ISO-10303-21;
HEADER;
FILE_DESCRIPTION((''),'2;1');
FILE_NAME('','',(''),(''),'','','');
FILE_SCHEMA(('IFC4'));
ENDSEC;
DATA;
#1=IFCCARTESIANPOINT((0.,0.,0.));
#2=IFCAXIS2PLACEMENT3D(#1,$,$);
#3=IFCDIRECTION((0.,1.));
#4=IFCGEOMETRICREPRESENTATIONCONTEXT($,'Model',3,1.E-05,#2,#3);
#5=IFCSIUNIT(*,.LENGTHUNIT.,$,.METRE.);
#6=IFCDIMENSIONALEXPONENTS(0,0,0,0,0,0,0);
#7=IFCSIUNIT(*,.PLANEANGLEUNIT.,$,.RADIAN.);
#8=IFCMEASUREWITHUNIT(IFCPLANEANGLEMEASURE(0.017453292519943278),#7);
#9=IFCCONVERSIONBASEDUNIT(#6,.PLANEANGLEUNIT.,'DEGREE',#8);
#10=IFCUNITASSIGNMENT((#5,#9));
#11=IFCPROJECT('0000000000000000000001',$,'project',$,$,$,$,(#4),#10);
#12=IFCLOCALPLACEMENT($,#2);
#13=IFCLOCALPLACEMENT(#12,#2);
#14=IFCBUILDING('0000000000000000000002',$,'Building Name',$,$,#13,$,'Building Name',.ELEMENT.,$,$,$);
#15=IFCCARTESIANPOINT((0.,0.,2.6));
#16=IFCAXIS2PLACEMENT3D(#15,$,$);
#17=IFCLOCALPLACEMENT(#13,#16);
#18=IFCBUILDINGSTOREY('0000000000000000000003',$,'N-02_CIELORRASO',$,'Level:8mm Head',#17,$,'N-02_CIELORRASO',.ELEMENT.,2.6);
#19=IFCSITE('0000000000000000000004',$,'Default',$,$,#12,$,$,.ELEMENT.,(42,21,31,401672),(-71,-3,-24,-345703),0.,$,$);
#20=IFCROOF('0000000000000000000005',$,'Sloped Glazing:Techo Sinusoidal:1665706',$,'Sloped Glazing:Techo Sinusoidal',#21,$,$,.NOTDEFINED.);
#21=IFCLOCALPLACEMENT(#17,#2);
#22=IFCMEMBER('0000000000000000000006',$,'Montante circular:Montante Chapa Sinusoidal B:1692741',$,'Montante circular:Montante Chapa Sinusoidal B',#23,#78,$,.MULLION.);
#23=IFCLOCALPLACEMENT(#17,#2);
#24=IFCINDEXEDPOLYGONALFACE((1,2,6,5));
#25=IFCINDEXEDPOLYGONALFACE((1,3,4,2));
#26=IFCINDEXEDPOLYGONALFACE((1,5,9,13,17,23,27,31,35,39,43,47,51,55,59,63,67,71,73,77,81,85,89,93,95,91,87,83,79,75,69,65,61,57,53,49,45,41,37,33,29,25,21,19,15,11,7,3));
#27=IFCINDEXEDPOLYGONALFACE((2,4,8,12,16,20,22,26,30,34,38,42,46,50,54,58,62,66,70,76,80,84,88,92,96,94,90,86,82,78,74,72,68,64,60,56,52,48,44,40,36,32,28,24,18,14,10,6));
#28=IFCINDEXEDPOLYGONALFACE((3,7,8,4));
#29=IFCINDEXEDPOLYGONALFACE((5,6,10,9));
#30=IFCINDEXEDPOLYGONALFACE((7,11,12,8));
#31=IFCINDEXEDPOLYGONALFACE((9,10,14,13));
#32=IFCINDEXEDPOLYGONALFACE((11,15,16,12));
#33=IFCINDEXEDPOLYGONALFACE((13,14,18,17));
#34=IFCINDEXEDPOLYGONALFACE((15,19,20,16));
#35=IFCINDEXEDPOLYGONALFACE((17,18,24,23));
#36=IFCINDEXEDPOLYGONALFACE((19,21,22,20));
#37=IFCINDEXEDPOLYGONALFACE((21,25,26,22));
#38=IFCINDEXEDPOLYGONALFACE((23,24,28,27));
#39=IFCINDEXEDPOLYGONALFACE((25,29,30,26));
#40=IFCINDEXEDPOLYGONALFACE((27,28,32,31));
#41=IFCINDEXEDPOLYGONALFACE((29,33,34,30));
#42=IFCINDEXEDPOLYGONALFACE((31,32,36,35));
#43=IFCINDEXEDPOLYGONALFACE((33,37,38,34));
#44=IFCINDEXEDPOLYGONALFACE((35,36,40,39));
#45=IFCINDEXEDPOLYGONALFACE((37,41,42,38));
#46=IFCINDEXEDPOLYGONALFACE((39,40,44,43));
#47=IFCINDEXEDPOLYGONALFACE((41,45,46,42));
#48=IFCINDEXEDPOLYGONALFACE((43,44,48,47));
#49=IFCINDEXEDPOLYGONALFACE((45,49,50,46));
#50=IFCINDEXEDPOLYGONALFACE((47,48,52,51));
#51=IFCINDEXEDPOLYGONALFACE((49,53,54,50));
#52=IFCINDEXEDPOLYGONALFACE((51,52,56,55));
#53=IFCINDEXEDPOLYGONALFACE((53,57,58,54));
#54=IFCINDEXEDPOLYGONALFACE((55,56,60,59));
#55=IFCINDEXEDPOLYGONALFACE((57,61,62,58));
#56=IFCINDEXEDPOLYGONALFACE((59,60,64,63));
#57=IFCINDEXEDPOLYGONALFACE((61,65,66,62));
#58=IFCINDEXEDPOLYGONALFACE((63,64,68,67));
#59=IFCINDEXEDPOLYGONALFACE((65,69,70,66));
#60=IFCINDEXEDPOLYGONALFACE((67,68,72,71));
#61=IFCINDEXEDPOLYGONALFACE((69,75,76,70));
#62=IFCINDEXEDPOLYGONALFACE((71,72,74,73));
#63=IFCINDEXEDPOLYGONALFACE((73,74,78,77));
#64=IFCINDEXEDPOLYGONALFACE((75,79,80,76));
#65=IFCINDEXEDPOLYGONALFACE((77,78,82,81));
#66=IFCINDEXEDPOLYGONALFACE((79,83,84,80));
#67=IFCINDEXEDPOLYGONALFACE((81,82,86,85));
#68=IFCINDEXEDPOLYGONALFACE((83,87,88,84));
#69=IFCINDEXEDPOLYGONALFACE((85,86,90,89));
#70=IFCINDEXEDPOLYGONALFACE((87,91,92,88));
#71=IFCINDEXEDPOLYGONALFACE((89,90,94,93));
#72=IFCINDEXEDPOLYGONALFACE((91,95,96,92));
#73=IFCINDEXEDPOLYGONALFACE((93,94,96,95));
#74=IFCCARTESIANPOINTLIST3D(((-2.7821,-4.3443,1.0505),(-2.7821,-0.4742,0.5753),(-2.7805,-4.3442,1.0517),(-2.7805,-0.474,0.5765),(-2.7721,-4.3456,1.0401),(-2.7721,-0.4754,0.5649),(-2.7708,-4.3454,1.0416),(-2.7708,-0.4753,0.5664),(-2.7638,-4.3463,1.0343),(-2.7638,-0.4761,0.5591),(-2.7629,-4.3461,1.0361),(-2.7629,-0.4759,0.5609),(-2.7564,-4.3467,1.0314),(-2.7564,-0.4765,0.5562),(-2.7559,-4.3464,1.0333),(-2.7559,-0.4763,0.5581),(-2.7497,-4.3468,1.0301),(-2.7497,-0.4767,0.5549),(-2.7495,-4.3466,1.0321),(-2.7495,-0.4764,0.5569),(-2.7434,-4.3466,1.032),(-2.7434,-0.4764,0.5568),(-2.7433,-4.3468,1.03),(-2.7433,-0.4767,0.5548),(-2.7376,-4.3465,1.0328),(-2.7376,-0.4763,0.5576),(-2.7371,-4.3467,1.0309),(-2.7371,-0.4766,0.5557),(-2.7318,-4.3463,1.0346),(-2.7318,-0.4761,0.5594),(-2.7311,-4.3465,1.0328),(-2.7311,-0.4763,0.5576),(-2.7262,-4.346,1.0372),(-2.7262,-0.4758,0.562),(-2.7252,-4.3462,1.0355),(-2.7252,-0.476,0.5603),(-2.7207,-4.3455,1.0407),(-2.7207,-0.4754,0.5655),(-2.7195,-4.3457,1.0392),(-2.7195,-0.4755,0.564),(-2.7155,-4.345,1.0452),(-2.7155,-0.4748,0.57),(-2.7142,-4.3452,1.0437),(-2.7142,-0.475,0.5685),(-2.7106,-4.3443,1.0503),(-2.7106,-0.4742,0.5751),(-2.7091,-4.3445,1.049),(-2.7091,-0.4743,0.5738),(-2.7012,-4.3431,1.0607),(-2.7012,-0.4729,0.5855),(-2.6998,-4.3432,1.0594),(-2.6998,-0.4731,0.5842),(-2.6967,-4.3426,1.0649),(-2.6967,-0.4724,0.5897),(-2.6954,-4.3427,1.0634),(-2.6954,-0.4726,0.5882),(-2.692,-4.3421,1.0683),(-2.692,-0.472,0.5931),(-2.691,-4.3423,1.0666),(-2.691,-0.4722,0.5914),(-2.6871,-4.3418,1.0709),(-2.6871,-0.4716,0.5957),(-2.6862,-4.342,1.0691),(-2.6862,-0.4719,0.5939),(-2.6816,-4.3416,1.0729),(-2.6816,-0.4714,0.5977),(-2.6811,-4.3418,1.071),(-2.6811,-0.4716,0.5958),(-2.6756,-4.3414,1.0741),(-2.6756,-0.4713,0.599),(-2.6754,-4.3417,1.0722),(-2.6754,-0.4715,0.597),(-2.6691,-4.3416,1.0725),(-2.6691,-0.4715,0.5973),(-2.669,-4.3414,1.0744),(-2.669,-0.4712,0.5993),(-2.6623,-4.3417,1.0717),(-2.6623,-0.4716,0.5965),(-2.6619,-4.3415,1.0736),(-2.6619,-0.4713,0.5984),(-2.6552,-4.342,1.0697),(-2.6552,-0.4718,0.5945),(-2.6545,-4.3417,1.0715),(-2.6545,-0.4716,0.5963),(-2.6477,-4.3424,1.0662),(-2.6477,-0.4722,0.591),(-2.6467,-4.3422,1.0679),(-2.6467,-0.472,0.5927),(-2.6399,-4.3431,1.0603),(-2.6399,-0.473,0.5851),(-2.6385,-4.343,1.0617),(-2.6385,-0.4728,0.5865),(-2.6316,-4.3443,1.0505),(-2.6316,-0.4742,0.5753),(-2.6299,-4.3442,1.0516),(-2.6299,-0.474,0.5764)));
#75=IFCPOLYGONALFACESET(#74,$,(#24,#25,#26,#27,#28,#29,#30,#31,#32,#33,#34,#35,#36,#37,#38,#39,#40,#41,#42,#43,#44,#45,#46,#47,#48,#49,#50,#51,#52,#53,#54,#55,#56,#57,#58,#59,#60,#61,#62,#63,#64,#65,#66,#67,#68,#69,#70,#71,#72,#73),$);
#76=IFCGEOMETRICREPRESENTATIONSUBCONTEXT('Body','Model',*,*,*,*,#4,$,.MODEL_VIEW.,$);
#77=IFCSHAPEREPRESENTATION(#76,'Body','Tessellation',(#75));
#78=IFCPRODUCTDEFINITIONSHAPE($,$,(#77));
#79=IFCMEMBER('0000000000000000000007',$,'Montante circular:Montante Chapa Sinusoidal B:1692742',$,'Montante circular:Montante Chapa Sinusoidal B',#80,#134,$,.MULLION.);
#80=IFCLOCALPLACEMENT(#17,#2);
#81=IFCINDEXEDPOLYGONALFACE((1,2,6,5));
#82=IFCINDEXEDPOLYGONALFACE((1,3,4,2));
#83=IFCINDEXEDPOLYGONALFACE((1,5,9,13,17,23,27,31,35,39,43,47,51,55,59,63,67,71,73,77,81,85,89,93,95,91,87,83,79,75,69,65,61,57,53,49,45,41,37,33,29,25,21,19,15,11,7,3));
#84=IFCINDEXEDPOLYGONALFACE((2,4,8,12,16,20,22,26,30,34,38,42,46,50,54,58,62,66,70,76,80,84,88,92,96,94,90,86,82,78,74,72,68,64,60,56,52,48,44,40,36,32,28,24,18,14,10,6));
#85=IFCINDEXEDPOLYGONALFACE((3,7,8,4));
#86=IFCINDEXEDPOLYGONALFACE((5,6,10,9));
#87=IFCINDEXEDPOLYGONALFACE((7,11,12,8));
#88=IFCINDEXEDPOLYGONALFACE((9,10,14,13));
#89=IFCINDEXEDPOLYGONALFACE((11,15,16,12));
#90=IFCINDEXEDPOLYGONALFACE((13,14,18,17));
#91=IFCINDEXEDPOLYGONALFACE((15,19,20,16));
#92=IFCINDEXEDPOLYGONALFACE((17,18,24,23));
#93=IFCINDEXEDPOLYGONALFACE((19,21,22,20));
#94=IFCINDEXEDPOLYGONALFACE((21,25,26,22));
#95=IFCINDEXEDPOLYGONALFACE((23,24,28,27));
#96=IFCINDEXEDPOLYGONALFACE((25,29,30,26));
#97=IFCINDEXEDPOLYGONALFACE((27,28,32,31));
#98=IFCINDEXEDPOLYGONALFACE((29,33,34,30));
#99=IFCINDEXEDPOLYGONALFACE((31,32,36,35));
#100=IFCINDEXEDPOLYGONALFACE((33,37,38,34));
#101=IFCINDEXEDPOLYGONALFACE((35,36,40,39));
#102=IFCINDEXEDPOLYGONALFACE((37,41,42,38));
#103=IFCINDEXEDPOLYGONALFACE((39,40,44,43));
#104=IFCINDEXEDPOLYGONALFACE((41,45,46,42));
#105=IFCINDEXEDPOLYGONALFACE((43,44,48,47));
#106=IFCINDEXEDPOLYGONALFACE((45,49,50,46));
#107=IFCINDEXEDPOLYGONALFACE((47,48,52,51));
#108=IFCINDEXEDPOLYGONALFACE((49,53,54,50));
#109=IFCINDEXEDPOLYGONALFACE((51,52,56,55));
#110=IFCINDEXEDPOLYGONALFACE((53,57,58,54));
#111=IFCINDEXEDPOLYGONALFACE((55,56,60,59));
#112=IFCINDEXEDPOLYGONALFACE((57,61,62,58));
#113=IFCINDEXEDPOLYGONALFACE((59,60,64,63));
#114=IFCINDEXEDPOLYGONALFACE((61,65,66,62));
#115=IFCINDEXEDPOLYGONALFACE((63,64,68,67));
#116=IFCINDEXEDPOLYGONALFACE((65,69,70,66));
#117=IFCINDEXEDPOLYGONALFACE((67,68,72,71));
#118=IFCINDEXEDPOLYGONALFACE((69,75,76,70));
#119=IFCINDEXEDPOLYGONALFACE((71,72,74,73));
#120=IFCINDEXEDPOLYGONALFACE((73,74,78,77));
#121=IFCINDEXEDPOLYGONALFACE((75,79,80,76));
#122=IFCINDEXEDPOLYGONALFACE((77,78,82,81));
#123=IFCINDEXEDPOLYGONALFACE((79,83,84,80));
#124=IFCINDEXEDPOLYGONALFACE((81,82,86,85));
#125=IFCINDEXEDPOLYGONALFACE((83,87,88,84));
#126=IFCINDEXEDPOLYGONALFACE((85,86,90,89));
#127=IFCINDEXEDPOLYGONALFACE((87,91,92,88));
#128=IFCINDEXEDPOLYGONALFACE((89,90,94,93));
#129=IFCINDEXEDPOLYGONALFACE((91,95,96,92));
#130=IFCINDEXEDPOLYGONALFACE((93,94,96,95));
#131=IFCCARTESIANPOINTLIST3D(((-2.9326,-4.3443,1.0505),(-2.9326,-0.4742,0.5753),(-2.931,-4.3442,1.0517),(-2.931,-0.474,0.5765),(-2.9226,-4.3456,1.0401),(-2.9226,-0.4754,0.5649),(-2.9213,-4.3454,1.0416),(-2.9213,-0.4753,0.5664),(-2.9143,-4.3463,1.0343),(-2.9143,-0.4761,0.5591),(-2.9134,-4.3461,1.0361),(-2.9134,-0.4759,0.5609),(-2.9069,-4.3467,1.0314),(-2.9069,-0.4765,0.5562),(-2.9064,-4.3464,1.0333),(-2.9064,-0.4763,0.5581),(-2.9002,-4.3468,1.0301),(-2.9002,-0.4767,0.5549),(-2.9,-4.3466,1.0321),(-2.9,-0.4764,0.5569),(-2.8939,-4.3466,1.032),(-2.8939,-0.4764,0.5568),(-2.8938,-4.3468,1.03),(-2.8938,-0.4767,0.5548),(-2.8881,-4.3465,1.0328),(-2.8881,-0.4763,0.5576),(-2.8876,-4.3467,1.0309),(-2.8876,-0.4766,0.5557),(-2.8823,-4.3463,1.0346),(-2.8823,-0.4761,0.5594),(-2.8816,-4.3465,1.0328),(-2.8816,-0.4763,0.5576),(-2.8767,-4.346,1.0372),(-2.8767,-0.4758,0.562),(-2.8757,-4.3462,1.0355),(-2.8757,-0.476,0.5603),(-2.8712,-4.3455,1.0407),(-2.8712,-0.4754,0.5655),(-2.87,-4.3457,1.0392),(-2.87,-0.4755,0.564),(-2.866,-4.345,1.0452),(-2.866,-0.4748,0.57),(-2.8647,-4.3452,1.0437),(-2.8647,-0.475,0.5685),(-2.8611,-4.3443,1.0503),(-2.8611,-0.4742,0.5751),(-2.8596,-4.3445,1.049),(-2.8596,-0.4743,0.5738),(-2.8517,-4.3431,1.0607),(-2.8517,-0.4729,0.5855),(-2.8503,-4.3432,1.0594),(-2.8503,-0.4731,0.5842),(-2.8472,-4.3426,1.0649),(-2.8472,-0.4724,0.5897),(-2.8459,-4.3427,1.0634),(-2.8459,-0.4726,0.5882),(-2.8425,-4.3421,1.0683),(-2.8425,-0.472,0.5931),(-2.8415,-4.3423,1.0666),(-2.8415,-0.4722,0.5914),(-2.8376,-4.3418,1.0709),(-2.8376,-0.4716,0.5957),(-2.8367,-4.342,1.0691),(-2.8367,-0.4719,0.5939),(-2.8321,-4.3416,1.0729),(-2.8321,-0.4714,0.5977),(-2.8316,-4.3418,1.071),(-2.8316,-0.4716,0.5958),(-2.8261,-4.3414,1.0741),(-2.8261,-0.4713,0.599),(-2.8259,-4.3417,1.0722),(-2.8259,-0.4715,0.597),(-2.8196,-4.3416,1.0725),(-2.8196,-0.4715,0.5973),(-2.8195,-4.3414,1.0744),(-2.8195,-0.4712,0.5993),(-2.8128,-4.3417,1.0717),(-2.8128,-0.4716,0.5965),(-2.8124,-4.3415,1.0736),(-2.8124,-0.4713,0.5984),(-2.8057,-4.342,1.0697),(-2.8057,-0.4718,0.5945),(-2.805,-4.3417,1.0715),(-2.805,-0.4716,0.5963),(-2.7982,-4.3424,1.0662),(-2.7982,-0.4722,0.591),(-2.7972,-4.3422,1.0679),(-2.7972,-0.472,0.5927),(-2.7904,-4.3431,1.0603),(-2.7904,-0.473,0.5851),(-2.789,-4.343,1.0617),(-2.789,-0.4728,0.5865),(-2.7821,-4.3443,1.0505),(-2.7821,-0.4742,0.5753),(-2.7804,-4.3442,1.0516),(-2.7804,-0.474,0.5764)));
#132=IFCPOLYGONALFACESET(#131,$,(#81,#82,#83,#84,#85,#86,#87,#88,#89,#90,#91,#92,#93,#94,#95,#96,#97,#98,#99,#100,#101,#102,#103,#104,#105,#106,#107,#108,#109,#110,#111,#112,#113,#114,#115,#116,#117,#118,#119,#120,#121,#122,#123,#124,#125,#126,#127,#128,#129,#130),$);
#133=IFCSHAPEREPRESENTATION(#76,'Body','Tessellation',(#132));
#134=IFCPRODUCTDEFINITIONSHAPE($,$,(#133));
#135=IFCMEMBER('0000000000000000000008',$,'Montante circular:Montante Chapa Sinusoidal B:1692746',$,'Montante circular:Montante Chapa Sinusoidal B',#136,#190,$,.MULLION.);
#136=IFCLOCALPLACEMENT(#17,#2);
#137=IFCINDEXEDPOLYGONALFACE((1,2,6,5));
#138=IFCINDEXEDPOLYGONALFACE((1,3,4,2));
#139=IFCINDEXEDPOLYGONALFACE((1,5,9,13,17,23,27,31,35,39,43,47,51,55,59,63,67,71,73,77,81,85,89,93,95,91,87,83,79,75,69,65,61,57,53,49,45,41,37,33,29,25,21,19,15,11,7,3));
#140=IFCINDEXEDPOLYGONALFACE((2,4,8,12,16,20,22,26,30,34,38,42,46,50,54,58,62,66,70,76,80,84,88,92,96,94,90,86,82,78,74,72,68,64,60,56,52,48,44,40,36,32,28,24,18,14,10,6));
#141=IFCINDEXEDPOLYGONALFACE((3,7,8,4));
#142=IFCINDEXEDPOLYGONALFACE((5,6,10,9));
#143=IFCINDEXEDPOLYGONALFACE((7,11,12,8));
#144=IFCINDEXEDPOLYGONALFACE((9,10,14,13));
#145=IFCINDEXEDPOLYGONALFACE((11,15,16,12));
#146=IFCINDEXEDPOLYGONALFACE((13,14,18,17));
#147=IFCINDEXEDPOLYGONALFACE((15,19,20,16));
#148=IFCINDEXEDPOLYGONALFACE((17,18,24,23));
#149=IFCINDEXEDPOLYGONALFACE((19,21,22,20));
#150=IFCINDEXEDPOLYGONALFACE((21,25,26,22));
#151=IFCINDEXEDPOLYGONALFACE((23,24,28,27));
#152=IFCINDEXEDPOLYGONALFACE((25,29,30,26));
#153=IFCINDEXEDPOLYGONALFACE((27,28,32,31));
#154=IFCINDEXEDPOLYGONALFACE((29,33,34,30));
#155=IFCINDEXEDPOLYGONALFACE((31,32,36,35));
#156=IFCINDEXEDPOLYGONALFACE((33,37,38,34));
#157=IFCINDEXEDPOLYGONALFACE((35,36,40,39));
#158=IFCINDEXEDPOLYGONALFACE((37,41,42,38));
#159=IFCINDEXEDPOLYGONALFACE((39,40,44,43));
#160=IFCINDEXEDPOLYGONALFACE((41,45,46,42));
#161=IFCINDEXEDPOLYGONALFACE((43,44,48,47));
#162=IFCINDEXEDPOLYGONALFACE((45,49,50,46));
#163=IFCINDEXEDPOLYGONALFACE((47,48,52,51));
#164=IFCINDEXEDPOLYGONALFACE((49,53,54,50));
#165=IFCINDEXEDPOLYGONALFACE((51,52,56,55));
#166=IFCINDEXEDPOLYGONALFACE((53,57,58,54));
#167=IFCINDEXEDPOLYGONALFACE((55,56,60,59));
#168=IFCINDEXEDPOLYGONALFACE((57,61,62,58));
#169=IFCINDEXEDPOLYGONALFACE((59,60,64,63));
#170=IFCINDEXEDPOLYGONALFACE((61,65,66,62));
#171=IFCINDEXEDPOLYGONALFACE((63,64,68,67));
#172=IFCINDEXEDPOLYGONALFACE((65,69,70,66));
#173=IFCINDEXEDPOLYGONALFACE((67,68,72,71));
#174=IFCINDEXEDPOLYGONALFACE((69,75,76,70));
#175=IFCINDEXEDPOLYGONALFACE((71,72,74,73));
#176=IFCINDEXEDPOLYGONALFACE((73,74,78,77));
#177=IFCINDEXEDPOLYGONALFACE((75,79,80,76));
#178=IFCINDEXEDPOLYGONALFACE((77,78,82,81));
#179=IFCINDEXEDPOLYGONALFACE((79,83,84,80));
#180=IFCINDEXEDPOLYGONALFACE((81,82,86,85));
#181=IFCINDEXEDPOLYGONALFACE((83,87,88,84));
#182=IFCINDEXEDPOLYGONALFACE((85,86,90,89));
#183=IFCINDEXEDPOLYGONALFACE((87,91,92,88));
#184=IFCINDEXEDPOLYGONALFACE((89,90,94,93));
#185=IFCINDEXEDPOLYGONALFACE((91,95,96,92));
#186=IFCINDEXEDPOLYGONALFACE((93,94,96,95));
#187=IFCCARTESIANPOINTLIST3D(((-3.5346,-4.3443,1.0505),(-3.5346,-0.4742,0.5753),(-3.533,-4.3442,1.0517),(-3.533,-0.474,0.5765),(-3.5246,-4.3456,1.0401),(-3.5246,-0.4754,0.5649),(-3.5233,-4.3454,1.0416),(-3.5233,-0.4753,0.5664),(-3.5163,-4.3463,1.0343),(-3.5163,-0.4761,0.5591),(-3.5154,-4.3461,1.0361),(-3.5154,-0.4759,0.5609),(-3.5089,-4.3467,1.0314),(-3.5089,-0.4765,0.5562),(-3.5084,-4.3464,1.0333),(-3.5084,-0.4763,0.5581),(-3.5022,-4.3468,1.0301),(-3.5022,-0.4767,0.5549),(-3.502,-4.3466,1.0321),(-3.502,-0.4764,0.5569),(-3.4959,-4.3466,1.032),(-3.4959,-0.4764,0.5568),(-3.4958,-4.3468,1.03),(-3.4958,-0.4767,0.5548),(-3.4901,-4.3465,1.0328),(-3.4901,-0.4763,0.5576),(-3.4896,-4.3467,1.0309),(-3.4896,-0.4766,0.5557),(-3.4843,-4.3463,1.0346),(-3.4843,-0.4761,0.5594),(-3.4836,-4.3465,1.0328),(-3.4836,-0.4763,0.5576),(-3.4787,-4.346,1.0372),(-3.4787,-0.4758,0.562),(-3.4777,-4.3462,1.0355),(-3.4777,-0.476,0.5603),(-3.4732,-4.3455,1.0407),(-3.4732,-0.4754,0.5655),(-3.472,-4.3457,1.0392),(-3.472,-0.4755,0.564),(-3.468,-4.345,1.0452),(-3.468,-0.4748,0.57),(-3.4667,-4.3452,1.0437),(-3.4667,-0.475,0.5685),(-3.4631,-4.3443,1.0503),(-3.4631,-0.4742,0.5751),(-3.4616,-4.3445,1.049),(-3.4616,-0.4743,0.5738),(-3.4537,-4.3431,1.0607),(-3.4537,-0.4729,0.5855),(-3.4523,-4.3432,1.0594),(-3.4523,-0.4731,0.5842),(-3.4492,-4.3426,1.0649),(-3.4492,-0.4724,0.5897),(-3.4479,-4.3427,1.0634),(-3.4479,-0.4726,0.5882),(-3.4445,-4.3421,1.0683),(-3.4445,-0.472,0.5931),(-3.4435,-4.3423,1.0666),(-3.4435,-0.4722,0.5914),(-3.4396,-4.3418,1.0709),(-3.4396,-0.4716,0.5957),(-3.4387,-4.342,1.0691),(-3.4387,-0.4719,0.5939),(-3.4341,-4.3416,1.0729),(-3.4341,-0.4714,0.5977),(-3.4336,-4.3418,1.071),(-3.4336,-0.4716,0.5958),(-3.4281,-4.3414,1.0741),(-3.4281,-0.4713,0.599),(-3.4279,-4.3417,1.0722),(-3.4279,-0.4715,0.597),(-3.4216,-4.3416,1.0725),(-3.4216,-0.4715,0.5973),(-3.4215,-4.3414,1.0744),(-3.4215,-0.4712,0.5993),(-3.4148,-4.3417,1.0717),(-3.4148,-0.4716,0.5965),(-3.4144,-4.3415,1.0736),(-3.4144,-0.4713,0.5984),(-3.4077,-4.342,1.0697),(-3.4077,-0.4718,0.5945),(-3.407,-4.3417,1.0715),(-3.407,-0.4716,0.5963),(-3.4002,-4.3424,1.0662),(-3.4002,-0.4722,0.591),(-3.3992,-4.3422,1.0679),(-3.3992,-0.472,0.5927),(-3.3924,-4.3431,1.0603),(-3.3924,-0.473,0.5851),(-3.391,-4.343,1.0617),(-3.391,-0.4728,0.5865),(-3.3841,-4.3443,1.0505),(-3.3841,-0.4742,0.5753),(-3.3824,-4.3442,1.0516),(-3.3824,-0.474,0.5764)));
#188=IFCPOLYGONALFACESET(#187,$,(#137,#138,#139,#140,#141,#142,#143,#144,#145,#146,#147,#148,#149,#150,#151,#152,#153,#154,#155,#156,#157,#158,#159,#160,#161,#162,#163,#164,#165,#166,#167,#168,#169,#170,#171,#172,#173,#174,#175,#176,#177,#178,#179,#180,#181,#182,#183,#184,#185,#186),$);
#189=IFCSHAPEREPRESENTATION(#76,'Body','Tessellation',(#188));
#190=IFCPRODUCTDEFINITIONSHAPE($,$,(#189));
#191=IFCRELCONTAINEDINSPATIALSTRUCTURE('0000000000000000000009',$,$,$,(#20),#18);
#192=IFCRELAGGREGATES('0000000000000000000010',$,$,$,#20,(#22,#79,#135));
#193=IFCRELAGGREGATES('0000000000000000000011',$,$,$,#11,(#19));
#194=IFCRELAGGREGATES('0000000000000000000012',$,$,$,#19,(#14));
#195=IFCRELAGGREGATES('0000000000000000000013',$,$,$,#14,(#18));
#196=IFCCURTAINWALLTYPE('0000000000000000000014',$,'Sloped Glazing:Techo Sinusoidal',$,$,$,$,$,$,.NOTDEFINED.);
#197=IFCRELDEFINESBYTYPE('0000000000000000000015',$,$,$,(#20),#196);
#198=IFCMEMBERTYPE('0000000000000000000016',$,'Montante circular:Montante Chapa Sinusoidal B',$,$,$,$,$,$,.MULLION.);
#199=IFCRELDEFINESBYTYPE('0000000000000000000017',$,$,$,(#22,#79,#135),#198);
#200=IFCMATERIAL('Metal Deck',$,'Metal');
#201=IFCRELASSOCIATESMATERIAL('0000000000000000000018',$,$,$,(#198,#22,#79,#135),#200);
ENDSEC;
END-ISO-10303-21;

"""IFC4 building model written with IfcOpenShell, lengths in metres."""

from ifc_helpers import new_model, entity, si_unit, converted_unit, direction, frame, origin, place, context, subcontext, project, spatial, indexed_curve, outline, extrude, source, transform, mapped, material, type_object, type_shapes, element, aggregate, save


model = new_model("IFC4")

# Units and contexts
model_context = context("Model", 3, precision=1e-05, world=origin(), true_north=direction((0.0, 1.0)))
body_context = subcontext(model_context, "Body", "Model", "MODEL_VIEW")
ifc_project = project(units=[si_unit("LENGTHUNIT", "METRE"), converted_unit("PLANEANGLEUNIT", "DEGREE", entity("IfcPlaneAngleMeasure", 0.017453292519943278), si_unit("PLANEANGLEUNIT", "RADIAN"), dimensions=[0, 0, 0, 0, 0, 0, 0])], contexts=[model_context])

# Site, building, storey
site_placement = place(None, origin())
site = spatial("IfcSite", under=ifc_project, at=site_placement, Name="Default", CompositionType="ELEMENT", RefLatitude=(42, 21, 31, 401672), RefLongitude=(-71, -3, -24, -345703), RefElevation=0.0)
building_placement = place(site_placement, origin())
building = spatial("IfcBuilding", under=site, at=building_placement, Name="Building Name", LongName="Building Name", CompositionType="ELEMENT")
storey_placement = place(building_placement, frame((0.0, 0.0, 2.6)))
storey = spatial("IfcBuildingStorey", under=building, at=storey_placement, Name="N-02_CIELORRASO", ObjectType="Level:8mm Head", LongName="N-02_CIELORRASO", CompositionType="ELEMENT", Elevation=2.6)

# Roof, members
curtain_wall_type = type_object("IfcCurtainWallType", Name="Sloped Glazing:Techo Sinusoidal", PredefinedType="NOTDEFINED")
ifc_material = material(Name="Metal Deck", Category="Metal")
roof_1_placement = place(storey_placement, frame((0.0, 0.0, -2.6)))
roof_1 = element("IfcRoof", 1, at=roof_1_placement, inside=storey, type_object=curtain_wall_type, Name="Sloped Glazing:Techo Sinusoidal:1665706", ObjectType="Sloped Glazing:Techo Sinusoidal", PredefinedType="NOTDEFINED")
member_type_1 = type_object("IfcMemberType", Name="Montante circular:Montante Chapa Sinusoidal B", PredefinedType="MULLION", material=ifc_material)
shared_shape_1 = source(origin(), body_context, "Body", "SweptSolid", [
    extrude(outline(indexed_curve([(0.0595, -0.0443), (0.0615, -0.0443), (0.0603, -0.031), (0.0572, -0.0213), (0.053, -0.0138), (0.0481, -0.0078), (0.0427, -0.003), (0.0372, 0.0005), (0.0315, 0.0029), (0.0259, 0.0044), (0.0203, 0.0051), (0.0146, 0.005), (0.0084, 0.0041), (-0.0053, 0.0009), (-0.0123, -0.0005), (-0.0191, -0.0012), (-0.0256, -0.001), (-0.0317, 0.0001), (-0.0375, 0.0019), (-0.0428, 0.0046), (-0.0477, 0.0081), (-0.0522, 0.0128), (-0.0563, 0.0191), (-0.0597, 0.0282), (-0.0617, 0.0421), (-0.0637, 0.042), (-0.0616, 0.0277), (-0.0581, 0.0182), (-0.0537, 0.0116), (-0.049, 0.0066), (-0.0438, 0.0028), (-0.0382, 0.0001), (-0.0322, -0.0019), (-0.0258, -0.003), (-0.019, -0.0032), (-0.012, -0.0025), (-0.0048, -0.0011), (0.0088, 0.0021), (0.0147, 0.003), (0.0202, 0.0031), (0.0255, 0.0024), (0.0309, 0.001), (0.0362, -0.0013), (0.0415, -0.0046), (0.0466, -0.0092), (0.0513, -0.0149), (0.0554, -0.0221), (0.0584, -0.0314), (0.0595, -0.0443)], self_intersect=False)), frame((-0.007, 0.0228, -3.8992), z_axis=(0.0, 0.0, 1.0), x_axis=(-0.819152, -0.573576, 0.0)), (0.0, 0.0, 1.0), 3.8992),
])
type_shapes(member_type_1, [shared_shape_1])
member_1_placement = place(roof_1_placement, frame((-2.7128, -4.3413, 3.6752), z_axis=(0.0, -0.992546, 0.121869), x_axis=(-1.0, 0.0, 0.0)))
member_1 = element("IfcMember", 2, at=member_1_placement, type_object=member_type_1, material=ifc_material, Name="Montante circular:Montante Chapa Sinusoidal B:1692741", ObjectType="Montante circular:Montante Chapa Sinusoidal B", PredefinedType="MULLION", context=body_context, shape_type="MappedRepresentation", body=[
    mapped(shared_shape_1, transform((0.0, 0.0, 0.0), scale=1.0)),
])
member_2_placement = place(roof_1_placement, frame((-2.8633, -4.3413, 3.6752), z_axis=(0.0, -0.992546, 0.121869), x_axis=(-1.0, 0.0, 0.0)))
member_2 = element("IfcMember", 3, at=member_2_placement, type_object=member_type_1, material=ifc_material, Name="Montante circular:Montante Chapa Sinusoidal B:1692742", ObjectType="Montante circular:Montante Chapa Sinusoidal B", PredefinedType="MULLION", context=body_context, shape_type="MappedRepresentation", body=[
    mapped(shared_shape_1, transform((0.0, 0.0, 0.0), scale=1.0)),
])
member_3_placement = place(roof_1_placement, frame((-3.4653, -4.3413, 3.6752), z_axis=(0.0, -0.992546, 0.121869), x_axis=(-1.0, 0.0, 0.0)))
member_3 = element("IfcMember", 4, at=member_3_placement, type_object=member_type_1, material=ifc_material, Name="Montante circular:Montante Chapa Sinusoidal B:1692746", ObjectType="Montante circular:Montante Chapa Sinusoidal B", PredefinedType="MULLION", context=body_context, shape_type="MappedRepresentation", body=[
    mapped(shared_shape_1, transform((0.0, 0.0, 0.0), scale=1.0)),
])
aggregate(roof_1, [member_1, member_2, member_3])

save(model, "model.ifc")
